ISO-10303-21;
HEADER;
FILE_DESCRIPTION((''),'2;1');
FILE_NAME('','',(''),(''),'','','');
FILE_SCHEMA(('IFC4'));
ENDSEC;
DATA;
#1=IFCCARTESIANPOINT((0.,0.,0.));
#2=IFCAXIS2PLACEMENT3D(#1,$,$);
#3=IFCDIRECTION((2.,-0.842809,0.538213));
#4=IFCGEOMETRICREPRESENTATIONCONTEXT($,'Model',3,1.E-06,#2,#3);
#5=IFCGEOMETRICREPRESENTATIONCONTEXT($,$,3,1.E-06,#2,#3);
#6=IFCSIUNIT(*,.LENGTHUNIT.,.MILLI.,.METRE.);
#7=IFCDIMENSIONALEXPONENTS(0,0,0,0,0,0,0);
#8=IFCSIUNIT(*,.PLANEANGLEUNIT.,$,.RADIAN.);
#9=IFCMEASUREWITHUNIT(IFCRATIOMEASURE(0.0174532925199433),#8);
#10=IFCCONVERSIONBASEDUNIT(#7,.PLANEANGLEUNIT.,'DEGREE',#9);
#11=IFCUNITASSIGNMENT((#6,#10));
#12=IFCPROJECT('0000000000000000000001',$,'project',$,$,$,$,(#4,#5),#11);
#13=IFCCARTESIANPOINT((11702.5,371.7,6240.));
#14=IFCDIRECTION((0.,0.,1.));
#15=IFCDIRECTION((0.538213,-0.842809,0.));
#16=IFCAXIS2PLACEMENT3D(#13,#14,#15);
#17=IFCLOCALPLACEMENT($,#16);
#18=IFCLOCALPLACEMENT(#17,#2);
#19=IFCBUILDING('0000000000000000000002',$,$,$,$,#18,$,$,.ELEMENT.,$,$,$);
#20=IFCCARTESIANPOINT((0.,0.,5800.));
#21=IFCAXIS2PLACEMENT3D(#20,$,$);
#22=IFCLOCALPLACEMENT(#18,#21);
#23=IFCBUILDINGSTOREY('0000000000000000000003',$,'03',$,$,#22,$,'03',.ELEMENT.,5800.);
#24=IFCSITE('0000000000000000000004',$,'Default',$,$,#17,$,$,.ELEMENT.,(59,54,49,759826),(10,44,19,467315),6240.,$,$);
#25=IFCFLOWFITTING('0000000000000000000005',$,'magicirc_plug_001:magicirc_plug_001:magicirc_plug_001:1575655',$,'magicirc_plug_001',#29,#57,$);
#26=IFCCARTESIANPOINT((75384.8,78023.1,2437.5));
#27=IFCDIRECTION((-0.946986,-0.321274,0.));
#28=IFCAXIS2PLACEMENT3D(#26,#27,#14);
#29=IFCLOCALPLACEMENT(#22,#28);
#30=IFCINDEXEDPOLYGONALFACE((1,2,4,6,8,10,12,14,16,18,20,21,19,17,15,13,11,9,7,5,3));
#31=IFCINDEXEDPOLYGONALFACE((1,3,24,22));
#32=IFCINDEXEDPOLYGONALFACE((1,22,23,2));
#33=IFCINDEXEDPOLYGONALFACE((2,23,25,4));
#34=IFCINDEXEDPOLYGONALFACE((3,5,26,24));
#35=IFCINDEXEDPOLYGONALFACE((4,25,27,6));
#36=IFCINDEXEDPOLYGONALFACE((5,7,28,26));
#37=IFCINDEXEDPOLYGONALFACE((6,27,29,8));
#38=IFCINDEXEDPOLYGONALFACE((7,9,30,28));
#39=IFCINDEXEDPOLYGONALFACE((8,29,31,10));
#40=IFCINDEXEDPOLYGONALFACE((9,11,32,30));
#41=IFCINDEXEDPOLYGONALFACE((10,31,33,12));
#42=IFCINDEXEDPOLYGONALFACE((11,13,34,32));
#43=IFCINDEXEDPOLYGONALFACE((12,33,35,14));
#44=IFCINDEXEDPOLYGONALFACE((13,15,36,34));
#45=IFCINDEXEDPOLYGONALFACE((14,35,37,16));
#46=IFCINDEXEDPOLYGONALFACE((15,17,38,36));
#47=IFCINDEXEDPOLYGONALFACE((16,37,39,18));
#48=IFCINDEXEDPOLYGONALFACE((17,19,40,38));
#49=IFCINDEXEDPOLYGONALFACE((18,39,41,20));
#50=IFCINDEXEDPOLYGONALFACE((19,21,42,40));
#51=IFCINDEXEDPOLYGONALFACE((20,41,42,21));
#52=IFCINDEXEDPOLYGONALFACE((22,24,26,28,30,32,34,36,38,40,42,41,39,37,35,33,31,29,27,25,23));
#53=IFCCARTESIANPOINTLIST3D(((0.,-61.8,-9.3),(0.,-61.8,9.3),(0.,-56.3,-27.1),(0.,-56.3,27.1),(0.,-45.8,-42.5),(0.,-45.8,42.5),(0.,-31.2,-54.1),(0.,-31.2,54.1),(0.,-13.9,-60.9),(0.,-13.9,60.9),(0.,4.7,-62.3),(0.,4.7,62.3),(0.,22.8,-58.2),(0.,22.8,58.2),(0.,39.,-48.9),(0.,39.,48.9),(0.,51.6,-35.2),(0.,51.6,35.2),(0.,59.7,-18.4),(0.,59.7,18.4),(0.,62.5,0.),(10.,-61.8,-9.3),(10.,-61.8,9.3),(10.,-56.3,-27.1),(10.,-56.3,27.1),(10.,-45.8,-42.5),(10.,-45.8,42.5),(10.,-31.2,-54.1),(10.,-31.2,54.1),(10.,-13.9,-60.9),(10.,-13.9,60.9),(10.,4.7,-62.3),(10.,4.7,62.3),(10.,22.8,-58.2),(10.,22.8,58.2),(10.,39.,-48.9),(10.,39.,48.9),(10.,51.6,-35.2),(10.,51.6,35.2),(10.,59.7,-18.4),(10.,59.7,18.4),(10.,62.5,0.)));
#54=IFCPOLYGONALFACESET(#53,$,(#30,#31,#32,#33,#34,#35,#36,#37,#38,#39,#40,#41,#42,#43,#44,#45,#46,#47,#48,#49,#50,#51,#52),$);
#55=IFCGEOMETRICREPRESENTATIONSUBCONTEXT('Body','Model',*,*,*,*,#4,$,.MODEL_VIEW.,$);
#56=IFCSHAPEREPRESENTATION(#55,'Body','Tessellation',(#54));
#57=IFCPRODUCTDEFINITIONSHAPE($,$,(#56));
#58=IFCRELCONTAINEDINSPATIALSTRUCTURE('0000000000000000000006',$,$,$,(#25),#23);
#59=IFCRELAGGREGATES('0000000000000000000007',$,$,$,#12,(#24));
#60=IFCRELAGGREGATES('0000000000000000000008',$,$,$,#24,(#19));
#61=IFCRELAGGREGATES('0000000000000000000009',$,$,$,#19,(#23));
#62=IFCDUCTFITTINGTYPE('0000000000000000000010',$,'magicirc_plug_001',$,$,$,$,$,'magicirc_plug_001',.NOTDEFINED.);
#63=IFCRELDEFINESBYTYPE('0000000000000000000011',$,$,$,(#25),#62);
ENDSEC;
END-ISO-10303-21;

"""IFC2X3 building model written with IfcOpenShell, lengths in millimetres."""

from ifc_helpers import new_model, entity, si_unit, converted_unit, direction, frame, frame_2d, origin, place, context, subcontext, project, spatial, circle, extrude, source, transform, mapped, type_object, type_shapes, element, save


model = new_model("IFC2X3")

# Units and contexts
model_context = context("Model", 3, precision=1e-06, world=origin(), true_north=direction((2.0, -0.842809, 0.538213)))
context_of_model = context(None, 3, precision=1e-06, world=origin(), true_north=direction((2.0, -0.842809, 0.538213)))
body_context = subcontext(model_context, "Body", "Model", "MODEL_VIEW")
ifc_project = project(units=[si_unit("LENGTHUNIT", "METRE", prefix="MILLI"), converted_unit("PLANEANGLEUNIT", "DEGREE", entity("IfcRatioMeasure", 0.0174532925199433), si_unit("PLANEANGLEUNIT", "RADIAN"), dimensions=[0, 0, 0, 0, 0, 0, 0])], contexts=[model_context, context_of_model])

# Site, building, storey
site_placement = place(None, frame((11702.5, 371.7, 6240.0), z_axis=(0.0, 0.0, 1.0), x_axis=(0.538213, -0.842809, 0.0)))
site = spatial("IfcSite", under=ifc_project, at=site_placement, Name="Default", CompositionType="ELEMENT", RefLatitude=(59, 54, 49, 759826), RefLongitude=(10, 44, 19, 467315), RefElevation=6240.0)
building_placement = place(site_placement, origin())
building = spatial("IfcBuilding", under=site, at=building_placement, CompositionType="ELEMENT")
storey_placement = place(building_placement, frame((0.0, 0.0, 5800.0)))
storey = spatial("IfcBuildingStorey", under=building, at=storey_placement, Name="03", LongName="03", CompositionType="ELEMENT", Elevation=5800.0)

# Flow fitting
duct_fitting_type_1 = type_object("IfcDuctFittingType", Name="magicirc_plug_001", ElementType="magicirc_plug_001", PredefinedType="NOTDEFINED")
shared_shape_1 = source(origin(), body_context, "Body", "SweptSolid", [
    extrude(circle(Radius=62.5, at=frame_2d((0.0, 0.0), x_axis=(1.0, 0.0))), frame((0.0, 0.0, 0.0), z_axis=(1.0, 0.0, 0.0), x_axis=(0.0, 1.0, 0.0)), (0.0, 0.0, 1.0), 10.0),
])
type_shapes(duct_fitting_type_1, [shared_shape_1])
for number, where, z_axis, x_axis, name in (
    (1, (75384.8, 78023.1, 2437.5), (-0.946986, -0.321274, 0.0), (0.0, 0.0, 1.0), "magicirc_plug_001:magicirc_plug_001:magicirc_plug_001:1575655"),
):
    element("IfcFlowFitting", number, at=place(storey_placement, frame(where, z_axis=z_axis, x_axis=x_axis)), inside=storey, type_object=duct_fitting_type_1, Name=name, ObjectType="magicirc_plug_001", context=body_context, shape_type="MappedRepresentation", body=[
        mapped(shared_shape_1, transform((0.0, 0.0, 0.0), scale=1.0)),
    ])

save(model, "model.ifc")
